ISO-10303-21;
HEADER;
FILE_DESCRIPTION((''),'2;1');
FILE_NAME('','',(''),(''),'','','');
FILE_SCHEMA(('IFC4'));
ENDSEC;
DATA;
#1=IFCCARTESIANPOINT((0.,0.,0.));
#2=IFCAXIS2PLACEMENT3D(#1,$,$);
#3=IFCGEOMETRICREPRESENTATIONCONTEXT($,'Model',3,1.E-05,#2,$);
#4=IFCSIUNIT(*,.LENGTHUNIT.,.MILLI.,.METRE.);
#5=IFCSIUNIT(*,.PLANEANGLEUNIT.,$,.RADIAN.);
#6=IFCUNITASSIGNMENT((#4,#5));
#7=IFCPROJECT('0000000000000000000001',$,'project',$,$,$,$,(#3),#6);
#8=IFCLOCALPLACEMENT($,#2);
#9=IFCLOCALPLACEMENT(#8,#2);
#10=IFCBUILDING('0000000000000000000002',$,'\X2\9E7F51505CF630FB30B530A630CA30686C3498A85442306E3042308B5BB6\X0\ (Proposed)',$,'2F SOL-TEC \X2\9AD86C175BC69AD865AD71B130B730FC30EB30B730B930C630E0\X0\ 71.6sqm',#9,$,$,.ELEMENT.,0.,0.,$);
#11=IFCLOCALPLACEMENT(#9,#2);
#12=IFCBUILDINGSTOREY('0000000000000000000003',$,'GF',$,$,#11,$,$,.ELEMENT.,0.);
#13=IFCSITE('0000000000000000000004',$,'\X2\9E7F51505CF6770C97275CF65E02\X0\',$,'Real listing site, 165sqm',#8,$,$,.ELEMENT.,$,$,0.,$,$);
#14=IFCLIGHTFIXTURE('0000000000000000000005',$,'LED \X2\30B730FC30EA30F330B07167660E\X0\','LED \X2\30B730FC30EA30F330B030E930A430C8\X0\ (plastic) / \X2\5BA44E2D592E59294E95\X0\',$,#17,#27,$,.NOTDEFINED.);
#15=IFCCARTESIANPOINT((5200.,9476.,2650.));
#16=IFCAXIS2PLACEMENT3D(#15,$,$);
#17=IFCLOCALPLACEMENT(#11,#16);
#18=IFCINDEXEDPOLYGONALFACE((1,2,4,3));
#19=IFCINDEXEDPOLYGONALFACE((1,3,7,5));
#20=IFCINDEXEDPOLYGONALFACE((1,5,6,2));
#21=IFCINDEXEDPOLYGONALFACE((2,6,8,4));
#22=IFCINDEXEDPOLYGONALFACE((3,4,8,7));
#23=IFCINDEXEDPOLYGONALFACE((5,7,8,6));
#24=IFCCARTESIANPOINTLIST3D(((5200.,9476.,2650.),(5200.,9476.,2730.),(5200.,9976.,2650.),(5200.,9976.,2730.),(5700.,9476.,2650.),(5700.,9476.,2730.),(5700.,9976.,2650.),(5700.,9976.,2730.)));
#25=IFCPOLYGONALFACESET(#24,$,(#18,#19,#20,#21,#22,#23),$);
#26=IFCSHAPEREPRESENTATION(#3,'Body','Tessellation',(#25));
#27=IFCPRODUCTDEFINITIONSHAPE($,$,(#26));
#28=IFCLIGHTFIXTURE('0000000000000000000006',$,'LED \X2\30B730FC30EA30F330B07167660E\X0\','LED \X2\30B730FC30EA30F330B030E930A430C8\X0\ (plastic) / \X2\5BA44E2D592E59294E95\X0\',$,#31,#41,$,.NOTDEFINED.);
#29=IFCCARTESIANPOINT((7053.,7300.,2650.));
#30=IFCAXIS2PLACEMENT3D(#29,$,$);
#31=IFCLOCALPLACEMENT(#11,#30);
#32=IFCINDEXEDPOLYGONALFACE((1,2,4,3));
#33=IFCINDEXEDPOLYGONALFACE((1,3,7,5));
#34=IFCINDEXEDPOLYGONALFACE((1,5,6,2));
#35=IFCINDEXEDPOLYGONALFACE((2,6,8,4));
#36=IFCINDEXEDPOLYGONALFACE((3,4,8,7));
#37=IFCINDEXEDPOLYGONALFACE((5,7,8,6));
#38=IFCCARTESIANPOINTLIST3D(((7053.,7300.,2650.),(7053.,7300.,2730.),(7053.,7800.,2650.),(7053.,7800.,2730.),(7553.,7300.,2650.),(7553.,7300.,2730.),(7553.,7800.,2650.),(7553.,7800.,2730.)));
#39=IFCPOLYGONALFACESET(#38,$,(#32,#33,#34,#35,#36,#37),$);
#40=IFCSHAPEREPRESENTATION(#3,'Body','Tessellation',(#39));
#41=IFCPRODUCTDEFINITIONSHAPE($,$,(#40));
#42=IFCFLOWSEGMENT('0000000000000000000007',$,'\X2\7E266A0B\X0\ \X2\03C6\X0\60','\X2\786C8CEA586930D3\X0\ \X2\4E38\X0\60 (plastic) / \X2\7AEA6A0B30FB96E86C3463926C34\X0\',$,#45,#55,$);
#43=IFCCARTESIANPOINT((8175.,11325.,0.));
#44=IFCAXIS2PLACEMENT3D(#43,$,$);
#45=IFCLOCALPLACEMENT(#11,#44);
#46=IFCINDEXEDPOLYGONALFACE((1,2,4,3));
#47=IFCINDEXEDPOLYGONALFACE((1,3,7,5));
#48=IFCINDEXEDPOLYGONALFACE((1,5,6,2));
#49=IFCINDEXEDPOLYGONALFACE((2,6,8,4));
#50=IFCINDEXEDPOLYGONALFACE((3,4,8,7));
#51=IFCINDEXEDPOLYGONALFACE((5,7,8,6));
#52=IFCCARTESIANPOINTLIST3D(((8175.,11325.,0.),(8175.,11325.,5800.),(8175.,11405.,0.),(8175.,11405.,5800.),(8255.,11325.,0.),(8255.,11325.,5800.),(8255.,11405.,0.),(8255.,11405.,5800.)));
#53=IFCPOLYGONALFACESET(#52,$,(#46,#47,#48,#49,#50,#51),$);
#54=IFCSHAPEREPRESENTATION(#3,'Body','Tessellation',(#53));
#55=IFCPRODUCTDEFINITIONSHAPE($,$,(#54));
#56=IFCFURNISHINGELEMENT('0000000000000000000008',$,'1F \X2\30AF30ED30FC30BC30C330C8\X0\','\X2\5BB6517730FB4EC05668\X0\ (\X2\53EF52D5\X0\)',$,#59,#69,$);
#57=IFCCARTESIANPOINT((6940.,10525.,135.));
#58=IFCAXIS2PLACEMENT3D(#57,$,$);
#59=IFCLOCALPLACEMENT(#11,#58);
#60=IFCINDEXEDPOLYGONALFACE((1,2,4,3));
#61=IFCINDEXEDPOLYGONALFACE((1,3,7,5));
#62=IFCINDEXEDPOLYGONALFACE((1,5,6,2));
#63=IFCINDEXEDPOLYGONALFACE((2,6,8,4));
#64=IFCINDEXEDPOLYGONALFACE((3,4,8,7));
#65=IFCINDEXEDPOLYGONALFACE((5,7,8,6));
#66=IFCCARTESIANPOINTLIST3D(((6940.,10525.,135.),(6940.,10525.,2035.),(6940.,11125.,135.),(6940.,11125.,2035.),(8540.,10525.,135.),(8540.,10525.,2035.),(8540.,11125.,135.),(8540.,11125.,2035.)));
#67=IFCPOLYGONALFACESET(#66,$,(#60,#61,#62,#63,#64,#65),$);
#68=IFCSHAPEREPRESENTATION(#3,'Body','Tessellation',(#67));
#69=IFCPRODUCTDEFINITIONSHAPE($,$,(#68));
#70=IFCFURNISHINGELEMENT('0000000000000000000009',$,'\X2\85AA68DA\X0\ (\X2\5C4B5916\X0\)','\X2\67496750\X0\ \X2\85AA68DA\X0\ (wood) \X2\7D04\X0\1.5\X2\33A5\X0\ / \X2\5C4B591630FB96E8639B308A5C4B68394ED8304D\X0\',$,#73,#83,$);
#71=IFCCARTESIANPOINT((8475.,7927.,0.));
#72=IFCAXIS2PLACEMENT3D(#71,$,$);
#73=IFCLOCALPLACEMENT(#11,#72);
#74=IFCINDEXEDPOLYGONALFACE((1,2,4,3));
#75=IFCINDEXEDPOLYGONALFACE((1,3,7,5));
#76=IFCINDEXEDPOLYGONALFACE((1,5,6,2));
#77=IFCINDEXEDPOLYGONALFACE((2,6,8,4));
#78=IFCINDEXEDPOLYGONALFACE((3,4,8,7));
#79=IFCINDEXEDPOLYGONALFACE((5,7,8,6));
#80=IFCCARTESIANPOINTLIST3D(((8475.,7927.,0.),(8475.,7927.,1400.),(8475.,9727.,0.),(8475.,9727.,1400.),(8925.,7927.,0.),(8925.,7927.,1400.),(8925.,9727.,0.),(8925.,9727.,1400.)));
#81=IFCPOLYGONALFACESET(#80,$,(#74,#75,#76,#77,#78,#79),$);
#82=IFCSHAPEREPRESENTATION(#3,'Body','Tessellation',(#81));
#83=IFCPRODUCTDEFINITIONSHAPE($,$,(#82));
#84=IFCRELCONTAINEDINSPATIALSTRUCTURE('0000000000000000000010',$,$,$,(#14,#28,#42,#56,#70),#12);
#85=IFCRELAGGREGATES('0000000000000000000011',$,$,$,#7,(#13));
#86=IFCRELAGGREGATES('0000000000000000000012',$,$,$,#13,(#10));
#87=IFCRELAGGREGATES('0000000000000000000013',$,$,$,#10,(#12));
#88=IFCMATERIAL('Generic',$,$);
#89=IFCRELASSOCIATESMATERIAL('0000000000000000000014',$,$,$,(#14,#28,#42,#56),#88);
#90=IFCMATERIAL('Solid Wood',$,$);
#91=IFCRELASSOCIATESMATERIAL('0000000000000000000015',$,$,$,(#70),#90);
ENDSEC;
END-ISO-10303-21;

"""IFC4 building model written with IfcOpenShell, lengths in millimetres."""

from ifc_helpers import new_model, si_unit, frame, frame_2d, origin, place, context, project, spatial, rectangle, extrude, material, element, save


model = new_model("IFC4")

# Units and contexts
model_context = context("Model", 3, precision=1e-05, world=origin())
ifc_project = project(units=[si_unit("LENGTHUNIT", "METRE", prefix="MILLI"), si_unit("PLANEANGLEUNIT", "RADIAN")], contexts=[model_context])

# Site, building, storey
site_placement = place(None, origin())
site = spatial("IfcSite", under=ifc_project, at=site_placement, Name="鹿児島県霧島市", ObjectType="Real listing site, 165sqm", CompositionType="ELEMENT", RefElevation=0.0)
building_placement = place(site_placement, origin())
building = spatial("IfcBuilding", under=site, at=building_placement, Name="鹿児島・サウナと水風呂のある家 (Proposed)", ObjectType="2F SOL-TEC 高気密高断熱シールシステム 71.6sqm", CompositionType="ELEMENT", ElevationOfRefHeight=0.0, ElevationOfTerrain=0.0)
storey_placement = place(building_placement, origin())
storey = spatial("IfcBuildingStorey", under=building, at=storey_placement, Name="GF", CompositionType="ELEMENT", Elevation=0.0)

# Shared definitions
ifc_material_1 = material(Name="Solid Wood")

# Shared definitions
ifc_material_2 = material(Name="Generic")

# Light fixtures
light_fixture_1_placement = place(storey_placement, frame((5200.0, 9476.0, 2650.0)))
element("IfcLightFixture", 1, at=light_fixture_1_placement, inside=storey, material=ifc_material_2, Name="LED シーリング照明", Description="LED シーリングライト (plastic) / 室中央天井", PredefinedType="NOTDEFINED", context=model_context, shape_type="SweptSolid", body=[
    extrude(rectangle(XDim=500.0, YDim=500.0, at=frame_2d((250.0, 250.0))), frame((5200.0, 9476.0, 2650.0)), (0.0, 0.0, 1.0), 80.0),
])
light_fixture_2_placement = place(storey_placement, frame((7053.0, 7300.0, 2650.0)))
element("IfcLightFixture", 2, at=light_fixture_2_placement, inside=storey, material=ifc_material_2, Name="LED シーリング照明", Description="LED シーリングライト (plastic) / 室中央天井", PredefinedType="NOTDEFINED", context=model_context, shape_type="SweptSolid", body=[
    extrude(rectangle(XDim=500.0, YDim=500.0, at=frame_2d((250.0, 250.0))), frame((7053.0, 7300.0, 2650.0)), (0.0, 0.0, 1.0), 80.0),
])

# Flow segment
flow_segment_placement = place(storey_placement, frame((8175.0, 11325.0, 0.0)))
element("IfcFlowSegment", 3, at=flow_segment_placement, inside=storey, material=ifc_material_2, Name="縦樋 φ60", Description="硬質塩ビ 丸60 (plastic) / 竪樋・雨水排水", context=model_context, shape_type="SweptSolid", body=[
    extrude(rectangle(XDim=80.0, YDim=80.0, at=frame_2d((40.0, 40.0))), frame((8175.0, 11325.0, 0.0)), (0.0, 0.0, 1.0), 5800.0),
])

# Furnishing elements
furnishing_1_placement = place(storey_placement, frame((6940.0, 10525.0, 135.0)))
element("IfcFurnishingElement", 4, at=furnishing_1_placement, inside=storey, material=ifc_material_2, Name="1F クローゼット", Description="家具・什器 (可動)", context=model_context, shape_type="SweptSolid", body=[
    extrude(rectangle(XDim=1600.0, YDim=600.0, at=frame_2d((800.0, 300.0))), frame((6940.0, 10525.0, 135.0)), (0.0, 0.0, 1.0), 1900.0),
])
furnishing_2_placement = place(storey_placement, frame((8475.0, 7927.0, 0.0)))
element("IfcFurnishingElement", 5, at=furnishing_2_placement, inside=storey, material=ifc_material_1, Name="薪棚 (屋外)", Description="杉材 薪棚 (wood) 約1.5㎥ / 屋外・雨掛り屋根付き", context=model_context, shape_type="SweptSolid", body=[
    extrude(rectangle(XDim=450.0, YDim=1800.0, at=frame_2d((225.0, 900.0))), frame((8475.0, 7927.0, 0.0)), (0.0, 0.0, 1.0), 1400.0),
])

save(model, "model.ifc")
